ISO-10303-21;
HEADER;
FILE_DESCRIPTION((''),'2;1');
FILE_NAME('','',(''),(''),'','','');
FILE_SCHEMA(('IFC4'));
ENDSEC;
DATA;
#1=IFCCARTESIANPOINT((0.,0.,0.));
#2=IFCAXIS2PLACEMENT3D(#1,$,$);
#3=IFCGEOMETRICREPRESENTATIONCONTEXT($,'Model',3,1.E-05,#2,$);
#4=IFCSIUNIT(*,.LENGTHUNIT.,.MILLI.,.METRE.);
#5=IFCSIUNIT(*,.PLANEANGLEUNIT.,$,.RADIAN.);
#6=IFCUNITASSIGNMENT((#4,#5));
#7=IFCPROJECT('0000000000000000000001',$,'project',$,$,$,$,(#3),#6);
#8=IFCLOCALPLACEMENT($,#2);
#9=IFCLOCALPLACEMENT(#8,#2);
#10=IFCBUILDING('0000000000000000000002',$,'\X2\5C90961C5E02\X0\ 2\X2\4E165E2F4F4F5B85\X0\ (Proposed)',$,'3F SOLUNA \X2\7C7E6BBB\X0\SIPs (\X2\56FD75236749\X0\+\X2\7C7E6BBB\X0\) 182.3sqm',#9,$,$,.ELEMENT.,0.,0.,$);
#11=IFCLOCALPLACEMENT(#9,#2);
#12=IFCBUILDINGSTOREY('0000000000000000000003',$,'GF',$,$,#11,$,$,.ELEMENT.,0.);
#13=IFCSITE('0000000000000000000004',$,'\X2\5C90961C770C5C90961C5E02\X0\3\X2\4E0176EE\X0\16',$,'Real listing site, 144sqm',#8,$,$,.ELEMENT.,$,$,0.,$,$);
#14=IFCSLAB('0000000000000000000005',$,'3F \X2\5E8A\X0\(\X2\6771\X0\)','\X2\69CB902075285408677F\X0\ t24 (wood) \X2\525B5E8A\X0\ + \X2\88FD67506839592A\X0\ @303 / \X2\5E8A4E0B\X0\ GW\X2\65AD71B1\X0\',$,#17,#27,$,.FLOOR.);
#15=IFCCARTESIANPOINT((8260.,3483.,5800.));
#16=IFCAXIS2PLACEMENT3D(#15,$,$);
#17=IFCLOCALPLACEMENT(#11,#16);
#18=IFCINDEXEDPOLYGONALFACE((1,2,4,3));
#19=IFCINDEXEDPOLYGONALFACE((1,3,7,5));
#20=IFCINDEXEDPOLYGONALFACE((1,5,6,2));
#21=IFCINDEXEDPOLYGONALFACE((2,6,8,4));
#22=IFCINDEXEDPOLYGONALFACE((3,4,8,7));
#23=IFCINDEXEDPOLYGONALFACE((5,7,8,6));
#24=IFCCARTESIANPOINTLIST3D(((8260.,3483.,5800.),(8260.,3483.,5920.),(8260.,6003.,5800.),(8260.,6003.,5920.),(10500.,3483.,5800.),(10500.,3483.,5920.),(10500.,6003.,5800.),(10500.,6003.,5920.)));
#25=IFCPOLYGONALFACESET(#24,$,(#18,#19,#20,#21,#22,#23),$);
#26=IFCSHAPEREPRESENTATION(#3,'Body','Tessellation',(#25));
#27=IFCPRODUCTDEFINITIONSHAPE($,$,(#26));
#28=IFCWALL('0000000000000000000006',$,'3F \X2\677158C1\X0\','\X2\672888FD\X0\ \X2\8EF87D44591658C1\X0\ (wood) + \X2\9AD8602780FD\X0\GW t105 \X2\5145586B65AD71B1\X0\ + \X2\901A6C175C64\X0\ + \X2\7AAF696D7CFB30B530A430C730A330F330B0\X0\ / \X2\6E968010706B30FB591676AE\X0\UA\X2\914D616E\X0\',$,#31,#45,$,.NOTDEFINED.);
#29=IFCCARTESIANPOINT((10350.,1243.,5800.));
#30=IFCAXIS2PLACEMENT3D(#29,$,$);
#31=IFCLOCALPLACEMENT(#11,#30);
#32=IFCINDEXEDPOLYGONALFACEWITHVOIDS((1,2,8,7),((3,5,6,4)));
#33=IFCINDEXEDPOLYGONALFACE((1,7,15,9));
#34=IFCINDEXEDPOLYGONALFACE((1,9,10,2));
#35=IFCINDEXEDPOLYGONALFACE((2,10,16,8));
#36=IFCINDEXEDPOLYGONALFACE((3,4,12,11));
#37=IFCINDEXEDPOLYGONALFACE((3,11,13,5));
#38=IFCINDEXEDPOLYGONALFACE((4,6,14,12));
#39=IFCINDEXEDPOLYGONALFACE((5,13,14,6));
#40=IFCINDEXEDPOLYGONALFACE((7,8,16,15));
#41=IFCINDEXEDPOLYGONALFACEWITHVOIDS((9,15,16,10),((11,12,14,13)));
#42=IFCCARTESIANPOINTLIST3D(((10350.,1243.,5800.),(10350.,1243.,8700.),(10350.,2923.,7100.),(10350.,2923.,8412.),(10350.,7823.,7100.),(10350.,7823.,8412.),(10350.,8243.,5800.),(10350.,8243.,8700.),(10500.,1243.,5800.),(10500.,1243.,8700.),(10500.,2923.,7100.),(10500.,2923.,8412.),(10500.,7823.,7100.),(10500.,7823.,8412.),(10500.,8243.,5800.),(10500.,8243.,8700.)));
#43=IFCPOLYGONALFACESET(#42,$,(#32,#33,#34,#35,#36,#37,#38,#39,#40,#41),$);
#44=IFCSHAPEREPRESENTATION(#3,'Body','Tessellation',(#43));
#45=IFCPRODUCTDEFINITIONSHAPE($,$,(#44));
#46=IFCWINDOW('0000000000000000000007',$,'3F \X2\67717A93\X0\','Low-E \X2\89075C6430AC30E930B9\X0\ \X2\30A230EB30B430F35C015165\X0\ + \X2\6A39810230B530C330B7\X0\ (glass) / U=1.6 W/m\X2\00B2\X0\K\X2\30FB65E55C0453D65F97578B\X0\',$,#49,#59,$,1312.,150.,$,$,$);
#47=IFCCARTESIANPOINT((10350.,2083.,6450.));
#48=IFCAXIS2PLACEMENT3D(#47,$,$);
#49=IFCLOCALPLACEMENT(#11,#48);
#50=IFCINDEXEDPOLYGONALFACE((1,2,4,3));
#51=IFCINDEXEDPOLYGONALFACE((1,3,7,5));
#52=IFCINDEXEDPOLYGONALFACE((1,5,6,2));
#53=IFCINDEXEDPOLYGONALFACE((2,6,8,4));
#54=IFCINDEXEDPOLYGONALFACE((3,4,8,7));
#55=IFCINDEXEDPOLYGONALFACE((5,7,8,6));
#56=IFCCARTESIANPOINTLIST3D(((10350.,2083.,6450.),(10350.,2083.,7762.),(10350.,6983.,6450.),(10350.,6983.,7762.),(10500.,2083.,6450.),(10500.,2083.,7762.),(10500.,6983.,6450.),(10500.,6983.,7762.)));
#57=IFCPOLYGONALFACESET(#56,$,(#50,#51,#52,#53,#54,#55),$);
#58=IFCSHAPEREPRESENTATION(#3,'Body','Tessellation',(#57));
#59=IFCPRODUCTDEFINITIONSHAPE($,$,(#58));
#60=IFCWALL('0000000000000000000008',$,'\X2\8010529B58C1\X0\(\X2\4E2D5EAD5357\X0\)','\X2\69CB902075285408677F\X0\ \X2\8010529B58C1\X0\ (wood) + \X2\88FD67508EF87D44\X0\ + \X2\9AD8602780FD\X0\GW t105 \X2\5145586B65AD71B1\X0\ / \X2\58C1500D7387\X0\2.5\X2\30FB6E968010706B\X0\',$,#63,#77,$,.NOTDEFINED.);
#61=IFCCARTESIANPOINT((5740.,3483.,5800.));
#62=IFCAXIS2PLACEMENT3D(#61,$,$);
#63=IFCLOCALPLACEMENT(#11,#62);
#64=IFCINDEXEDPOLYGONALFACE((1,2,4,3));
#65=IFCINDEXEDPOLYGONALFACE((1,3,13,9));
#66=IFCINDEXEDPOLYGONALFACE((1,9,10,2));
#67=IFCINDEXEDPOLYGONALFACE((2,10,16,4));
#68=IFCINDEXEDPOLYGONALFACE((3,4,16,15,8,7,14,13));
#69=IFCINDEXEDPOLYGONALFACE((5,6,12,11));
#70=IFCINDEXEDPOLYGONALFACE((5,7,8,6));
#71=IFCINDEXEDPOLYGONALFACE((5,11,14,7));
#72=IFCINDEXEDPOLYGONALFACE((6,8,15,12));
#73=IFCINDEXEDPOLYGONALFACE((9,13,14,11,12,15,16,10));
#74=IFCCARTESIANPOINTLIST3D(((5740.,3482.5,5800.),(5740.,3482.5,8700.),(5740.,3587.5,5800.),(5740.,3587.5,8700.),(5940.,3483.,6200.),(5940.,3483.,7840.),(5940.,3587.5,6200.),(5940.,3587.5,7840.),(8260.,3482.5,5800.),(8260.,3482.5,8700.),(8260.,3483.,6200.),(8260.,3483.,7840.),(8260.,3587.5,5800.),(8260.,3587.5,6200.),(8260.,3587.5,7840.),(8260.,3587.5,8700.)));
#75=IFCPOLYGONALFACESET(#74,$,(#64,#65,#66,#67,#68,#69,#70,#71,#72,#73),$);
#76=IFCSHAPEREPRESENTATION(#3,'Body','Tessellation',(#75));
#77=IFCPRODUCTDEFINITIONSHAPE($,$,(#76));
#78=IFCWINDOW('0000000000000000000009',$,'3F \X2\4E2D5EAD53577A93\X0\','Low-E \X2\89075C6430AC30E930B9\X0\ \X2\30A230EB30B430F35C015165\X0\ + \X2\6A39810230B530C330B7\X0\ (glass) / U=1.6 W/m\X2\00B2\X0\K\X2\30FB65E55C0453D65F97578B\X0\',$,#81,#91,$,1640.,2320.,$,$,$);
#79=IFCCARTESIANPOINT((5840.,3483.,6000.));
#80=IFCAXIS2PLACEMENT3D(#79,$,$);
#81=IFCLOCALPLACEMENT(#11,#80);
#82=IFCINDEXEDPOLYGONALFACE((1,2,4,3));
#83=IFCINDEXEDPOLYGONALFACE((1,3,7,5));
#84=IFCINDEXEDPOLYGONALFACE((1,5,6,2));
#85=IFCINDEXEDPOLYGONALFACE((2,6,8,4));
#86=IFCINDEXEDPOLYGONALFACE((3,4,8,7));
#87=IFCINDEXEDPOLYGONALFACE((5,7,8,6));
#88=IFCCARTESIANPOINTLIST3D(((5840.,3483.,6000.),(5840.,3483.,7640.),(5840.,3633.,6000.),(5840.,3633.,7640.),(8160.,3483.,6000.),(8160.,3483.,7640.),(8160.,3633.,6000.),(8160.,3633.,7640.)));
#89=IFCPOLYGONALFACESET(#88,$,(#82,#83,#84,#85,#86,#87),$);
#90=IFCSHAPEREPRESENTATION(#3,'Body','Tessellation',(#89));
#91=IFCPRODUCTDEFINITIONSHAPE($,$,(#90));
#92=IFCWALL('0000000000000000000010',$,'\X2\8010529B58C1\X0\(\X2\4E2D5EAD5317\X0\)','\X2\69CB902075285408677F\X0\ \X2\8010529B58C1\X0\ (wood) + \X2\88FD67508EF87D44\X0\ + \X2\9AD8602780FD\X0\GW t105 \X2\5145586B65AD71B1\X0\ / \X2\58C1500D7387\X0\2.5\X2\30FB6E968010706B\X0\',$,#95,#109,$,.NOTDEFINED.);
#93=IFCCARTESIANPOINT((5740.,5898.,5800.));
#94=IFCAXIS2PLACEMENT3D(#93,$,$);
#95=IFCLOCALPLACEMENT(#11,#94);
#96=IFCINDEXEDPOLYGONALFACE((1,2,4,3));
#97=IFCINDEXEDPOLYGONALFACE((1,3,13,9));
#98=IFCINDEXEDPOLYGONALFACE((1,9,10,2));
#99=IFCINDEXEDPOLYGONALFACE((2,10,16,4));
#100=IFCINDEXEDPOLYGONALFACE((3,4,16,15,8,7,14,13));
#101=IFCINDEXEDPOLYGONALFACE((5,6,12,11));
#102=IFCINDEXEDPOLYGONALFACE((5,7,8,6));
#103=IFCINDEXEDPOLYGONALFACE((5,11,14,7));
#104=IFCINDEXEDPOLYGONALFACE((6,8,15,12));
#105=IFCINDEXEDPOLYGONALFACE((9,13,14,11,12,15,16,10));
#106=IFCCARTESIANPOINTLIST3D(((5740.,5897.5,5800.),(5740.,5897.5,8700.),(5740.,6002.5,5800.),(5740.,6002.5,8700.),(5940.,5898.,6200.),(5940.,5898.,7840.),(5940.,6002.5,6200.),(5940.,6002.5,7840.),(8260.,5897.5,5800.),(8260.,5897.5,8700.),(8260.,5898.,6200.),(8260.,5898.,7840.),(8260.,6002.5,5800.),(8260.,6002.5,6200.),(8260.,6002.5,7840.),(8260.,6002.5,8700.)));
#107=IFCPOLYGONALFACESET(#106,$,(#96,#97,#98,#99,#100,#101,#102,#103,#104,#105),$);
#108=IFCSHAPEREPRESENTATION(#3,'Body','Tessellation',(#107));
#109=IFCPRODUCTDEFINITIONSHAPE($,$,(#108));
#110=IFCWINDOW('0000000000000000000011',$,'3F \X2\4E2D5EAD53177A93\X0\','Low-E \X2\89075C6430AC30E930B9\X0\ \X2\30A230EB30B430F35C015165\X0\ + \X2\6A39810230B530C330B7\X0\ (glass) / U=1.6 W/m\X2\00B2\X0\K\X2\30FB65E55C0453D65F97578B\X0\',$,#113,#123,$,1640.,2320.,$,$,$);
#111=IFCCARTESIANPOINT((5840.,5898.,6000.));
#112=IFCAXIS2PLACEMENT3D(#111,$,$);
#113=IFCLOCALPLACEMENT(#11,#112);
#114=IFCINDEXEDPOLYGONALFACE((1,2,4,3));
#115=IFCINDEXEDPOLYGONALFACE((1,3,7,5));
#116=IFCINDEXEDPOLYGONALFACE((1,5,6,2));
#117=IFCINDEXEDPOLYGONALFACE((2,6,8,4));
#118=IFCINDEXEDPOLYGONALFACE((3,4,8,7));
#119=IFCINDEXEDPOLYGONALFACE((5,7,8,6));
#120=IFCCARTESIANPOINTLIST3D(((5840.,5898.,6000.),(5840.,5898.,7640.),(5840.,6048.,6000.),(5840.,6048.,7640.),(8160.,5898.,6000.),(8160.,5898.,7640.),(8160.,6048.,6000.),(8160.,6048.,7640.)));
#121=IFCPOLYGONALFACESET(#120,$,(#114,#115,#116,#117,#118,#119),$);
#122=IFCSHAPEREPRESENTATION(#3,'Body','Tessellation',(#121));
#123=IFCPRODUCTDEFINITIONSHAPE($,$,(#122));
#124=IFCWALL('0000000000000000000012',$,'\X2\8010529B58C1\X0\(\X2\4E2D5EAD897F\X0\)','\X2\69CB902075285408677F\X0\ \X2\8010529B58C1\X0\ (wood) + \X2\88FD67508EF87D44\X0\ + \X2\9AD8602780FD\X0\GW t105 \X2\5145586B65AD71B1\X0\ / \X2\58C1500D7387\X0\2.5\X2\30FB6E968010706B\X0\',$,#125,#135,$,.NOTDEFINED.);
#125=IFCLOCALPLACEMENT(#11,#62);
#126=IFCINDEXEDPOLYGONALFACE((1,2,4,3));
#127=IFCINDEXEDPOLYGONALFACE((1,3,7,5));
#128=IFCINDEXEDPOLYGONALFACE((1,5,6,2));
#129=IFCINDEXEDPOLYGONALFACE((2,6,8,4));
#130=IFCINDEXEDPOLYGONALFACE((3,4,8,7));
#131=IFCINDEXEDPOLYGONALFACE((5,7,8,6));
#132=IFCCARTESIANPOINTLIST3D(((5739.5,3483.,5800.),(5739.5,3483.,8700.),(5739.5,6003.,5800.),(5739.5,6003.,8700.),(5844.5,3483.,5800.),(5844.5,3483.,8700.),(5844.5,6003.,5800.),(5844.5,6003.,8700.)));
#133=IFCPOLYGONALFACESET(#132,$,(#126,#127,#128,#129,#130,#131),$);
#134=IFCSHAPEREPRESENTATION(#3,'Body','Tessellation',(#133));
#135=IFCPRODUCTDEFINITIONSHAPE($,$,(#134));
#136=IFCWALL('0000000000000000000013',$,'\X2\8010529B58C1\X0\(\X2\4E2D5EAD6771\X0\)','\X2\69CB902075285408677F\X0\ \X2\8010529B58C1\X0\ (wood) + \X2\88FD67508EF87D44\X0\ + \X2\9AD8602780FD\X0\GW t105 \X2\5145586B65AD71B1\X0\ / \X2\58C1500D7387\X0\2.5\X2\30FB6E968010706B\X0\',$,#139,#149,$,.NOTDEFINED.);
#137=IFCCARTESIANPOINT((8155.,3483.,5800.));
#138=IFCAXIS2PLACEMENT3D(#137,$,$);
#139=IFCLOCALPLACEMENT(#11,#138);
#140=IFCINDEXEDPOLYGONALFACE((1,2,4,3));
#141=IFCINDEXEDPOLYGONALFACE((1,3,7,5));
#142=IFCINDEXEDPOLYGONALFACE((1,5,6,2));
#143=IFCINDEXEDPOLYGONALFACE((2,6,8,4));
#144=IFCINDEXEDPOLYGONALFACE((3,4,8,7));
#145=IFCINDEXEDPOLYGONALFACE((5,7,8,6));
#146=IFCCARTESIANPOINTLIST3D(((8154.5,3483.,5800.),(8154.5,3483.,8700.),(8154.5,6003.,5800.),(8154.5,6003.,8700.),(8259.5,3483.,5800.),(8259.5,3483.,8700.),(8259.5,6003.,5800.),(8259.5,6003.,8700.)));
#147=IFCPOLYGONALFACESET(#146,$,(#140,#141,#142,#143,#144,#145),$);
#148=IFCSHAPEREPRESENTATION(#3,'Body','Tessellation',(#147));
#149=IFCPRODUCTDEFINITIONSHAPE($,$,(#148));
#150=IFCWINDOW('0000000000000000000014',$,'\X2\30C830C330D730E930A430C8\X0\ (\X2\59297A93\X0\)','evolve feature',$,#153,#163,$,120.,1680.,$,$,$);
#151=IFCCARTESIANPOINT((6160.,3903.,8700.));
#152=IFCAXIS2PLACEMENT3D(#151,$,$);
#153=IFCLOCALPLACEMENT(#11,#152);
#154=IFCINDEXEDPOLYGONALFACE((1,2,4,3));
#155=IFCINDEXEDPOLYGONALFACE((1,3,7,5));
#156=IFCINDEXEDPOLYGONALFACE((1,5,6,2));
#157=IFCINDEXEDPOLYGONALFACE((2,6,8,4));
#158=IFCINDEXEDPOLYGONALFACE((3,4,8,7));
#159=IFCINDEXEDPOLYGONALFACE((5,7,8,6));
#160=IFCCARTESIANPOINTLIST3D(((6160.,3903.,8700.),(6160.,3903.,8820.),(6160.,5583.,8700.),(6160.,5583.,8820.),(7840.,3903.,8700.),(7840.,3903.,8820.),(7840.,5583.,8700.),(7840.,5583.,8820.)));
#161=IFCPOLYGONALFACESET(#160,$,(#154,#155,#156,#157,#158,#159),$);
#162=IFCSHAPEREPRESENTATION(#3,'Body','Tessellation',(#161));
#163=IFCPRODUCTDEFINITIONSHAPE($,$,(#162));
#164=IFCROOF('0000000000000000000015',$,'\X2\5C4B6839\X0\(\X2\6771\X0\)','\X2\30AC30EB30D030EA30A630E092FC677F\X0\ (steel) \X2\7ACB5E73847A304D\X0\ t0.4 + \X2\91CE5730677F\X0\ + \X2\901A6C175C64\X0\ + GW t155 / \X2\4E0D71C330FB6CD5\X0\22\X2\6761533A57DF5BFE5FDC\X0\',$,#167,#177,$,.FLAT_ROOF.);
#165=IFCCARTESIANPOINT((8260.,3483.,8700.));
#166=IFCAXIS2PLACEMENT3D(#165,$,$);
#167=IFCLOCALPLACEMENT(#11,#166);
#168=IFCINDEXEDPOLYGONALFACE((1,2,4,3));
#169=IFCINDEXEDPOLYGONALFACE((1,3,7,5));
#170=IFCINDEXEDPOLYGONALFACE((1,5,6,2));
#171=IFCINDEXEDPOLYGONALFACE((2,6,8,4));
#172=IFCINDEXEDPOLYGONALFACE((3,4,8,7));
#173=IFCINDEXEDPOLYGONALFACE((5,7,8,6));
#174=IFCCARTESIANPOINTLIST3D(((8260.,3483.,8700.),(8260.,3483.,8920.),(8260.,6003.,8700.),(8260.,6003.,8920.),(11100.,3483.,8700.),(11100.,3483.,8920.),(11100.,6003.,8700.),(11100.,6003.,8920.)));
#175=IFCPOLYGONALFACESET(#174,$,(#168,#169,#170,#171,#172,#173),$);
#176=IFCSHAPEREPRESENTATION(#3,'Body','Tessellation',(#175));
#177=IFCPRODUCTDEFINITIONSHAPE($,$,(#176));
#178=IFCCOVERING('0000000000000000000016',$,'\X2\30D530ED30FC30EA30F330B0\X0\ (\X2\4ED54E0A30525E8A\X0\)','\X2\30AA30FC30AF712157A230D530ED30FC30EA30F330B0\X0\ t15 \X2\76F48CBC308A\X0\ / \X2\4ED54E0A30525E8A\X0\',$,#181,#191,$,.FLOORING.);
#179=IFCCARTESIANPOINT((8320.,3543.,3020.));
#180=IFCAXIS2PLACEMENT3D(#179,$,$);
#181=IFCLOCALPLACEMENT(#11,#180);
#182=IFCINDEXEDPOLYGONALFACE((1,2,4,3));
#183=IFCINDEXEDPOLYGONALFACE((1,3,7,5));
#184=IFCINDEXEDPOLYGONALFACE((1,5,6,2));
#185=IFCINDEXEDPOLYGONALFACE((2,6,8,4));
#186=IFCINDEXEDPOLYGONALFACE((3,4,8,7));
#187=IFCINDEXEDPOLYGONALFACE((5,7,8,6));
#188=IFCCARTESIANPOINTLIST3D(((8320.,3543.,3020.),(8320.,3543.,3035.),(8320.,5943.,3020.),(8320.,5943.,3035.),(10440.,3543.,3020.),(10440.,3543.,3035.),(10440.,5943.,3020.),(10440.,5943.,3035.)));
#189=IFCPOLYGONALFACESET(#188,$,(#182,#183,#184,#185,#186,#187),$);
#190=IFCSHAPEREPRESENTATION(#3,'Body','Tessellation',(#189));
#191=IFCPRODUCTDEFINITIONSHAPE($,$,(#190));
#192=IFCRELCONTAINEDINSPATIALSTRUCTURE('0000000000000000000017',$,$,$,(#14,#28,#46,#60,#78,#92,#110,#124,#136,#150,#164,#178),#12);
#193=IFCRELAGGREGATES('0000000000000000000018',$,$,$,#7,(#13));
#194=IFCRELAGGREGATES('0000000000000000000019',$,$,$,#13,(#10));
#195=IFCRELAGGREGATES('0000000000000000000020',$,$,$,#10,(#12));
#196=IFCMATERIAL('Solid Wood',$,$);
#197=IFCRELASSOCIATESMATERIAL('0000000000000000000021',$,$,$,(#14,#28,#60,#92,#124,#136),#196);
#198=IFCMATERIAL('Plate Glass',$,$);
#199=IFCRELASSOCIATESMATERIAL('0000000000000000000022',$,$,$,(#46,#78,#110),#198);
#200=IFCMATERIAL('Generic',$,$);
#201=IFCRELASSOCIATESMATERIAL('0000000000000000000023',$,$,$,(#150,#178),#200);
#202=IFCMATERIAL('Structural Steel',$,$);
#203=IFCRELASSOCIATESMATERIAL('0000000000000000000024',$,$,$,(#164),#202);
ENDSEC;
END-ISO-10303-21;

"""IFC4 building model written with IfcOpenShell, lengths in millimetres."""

from ifc_helpers import new_model, si_unit, frame, frame_2d, origin, place, context, project, spatial, rectangle, extrude, material, element, fill, save


model = new_model("IFC4")

# Units and contexts
model_context = context("Model", 3, precision=1e-05, world=origin())
ifc_project = project(units=[si_unit("LENGTHUNIT", "METRE", prefix="MILLI"), si_unit("PLANEANGLEUNIT", "RADIAN")], contexts=[model_context])

# Site, building, storey
site_placement = place(None, origin())
site = spatial("IfcSite", under=ifc_project, at=site_placement, Name="岐阜県岐阜市3丁目16", ObjectType="Real listing site, 144sqm", CompositionType="ELEMENT", RefElevation=0.0)
building_placement = place(site_placement, origin())
building = spatial("IfcBuilding", under=site, at=building_placement, Name="岐阜市 2世帯住宅 (Proposed)", ObjectType="3F SOLUNA 籾殻SIPs (国産杉+籾殻) 182.3sqm", CompositionType="ELEMENT", ElevationOfRefHeight=0.0, ElevationOfTerrain=0.0)
storey_placement = place(building_placement, origin())
storey = spatial("IfcBuildingStorey", under=building, at=storey_placement, Name="GF", CompositionType="ELEMENT", Elevation=0.0)

# Slab
ifc_material_1 = material(Name="Solid Wood")
slab_placement = place(storey_placement, frame((8260.0, 3483.0, 5800.0)))
element("IfcSlab", 1, at=slab_placement, inside=storey, material=ifc_material_1, Name="3F 床(東)", Description="構造用合板 t24 (wood) 剛床 + 製材根太 @303 / 床下 GW断熱", PredefinedType="FLOOR", context=model_context, shape_type="SweptSolid", body=[
    extrude(rectangle(XDim=2240.0, YDim=2520.0, at=frame_2d((1120.0, 1260.0))), frame((8260.0, 3483.0, 5800.0)), (0.0, 0.0, 1.0), 120.0),
])

# Walls, openings, windows
wall_1_placement = place(storey_placement, frame((10350.0, 1243.0, 5800.0)))
wall_1 = element("IfcWall", 2, at=wall_1_placement, inside=storey, material=ifc_material_1, Name="3F 東壁", Description="木製 軸組外壁 (wood) + 高性能GW t105 充填断熱 + 通気層 + 窯業系サイディング / 準耐火・外皮UA配慮", PredefinedType="NOTDEFINED", context=model_context, shape_type="SweptSolid", body=[
    extrude(rectangle(XDim=150.0, YDim=7000.0, at=frame_2d((75.0, 3500.0))), frame((10350.0, 1243.0, 5800.0)), (0.0, 0.0, 1.0), 2900.0),
])
opening_1_placement = place(storey_placement, frame((10350.0, 2083.0, 6450.0)))
opening_1 = element("IfcOpeningElement", 3, at=opening_1_placement, cuts=wall_1, PredefinedType="NOTDEFINED", context=model_context, shape_type="SweptSolid", body=[
    extrude(rectangle(XDim=150.0, YDim=4900.0, at=frame_2d((75.0, 2450.0))), frame((10350.0, 2083.0, 6450.0)), (0.0, 0.0, 1.0), 1312.0),
])
ifc_material_2 = material(Name="Plate Glass")
window_1_placement = place(storey_placement, frame((10350.0, 2083.0, 6450.0)))
window_1 = element("IfcWindow", 4, at=window_1_placement, inside=storey, material=ifc_material_2, Name="3F 東窓", Description="Low-E 複層ガラス アルゴン封入 + 樹脂サッシ (glass) / U=1.6 W/m²K・日射取得型", OverallHeight=1312.0, OverallWidth=150.0, context=model_context, shape_type="SweptSolid", body=[
    extrude(rectangle(XDim=150.0, YDim=4900.0, at=frame_2d((75.0, 2450.0))), frame((10350.0, 2083.0, 6450.0)), (0.0, 0.0, 1.0), 1312.0),
])
fill(opening_1, window_1)
wall_2_placement = place(storey_placement, frame((5740.0, 3483.0, 5800.0)))
wall_2 = element("IfcWall", 5, at=wall_2_placement, inside=storey, material=ifc_material_1, Name="耐力壁(中庭南)", Description="構造用合板 耐力壁 (wood) + 製材軸組 + 高性能GW t105 充填断熱 / 壁倍率2.5・準耐火", PredefinedType="NOTDEFINED", context=model_context, shape_type="SweptSolid", body=[
    extrude(rectangle(XDim=2520.0, YDim=105.0, at=frame_2d((1260.0, 52.0))), frame((5740.0, 3483.0, 5800.0)), (0.0, 0.0, 1.0), 2900.0),
])
opening_2_placement = place(storey_placement, frame((5840.0, 3483.0, 6000.0)))
opening_2 = element("IfcOpeningElement", 6, at=opening_2_placement, cuts=wall_2, PredefinedType="NOTDEFINED", context=model_context, shape_type="SweptSolid", body=[
    extrude(rectangle(XDim=2320.0, YDim=150.0, at=frame_2d((1160.0, 75.0))), frame((5840.0, 3483.0, 6000.0)), (0.0, 0.0, 1.0), 1640.0),
])
window_2_placement = place(storey_placement, frame((5840.0, 3483.0, 6000.0)))
window_2 = element("IfcWindow", 7, at=window_2_placement, inside=storey, material=ifc_material_2, Name="3F 中庭南窓", Description="Low-E 複層ガラス アルゴン封入 + 樹脂サッシ (glass) / U=1.6 W/m²K・日射取得型", OverallHeight=1640.0, OverallWidth=2320.0, context=model_context, shape_type="SweptSolid", body=[
    extrude(rectangle(XDim=2320.0, YDim=150.0, at=frame_2d((1160.0, 75.0))), frame((5840.0, 3483.0, 6000.0)), (0.0, 0.0, 1.0), 1640.0),
])
fill(opening_2, window_2)
wall_3_placement = place(storey_placement, frame((5740.0, 5898.0, 5800.0)))
wall_3 = element("IfcWall", 8, at=wall_3_placement, inside=storey, material=ifc_material_1, Name="耐力壁(中庭北)", Description="構造用合板 耐力壁 (wood) + 製材軸組 + 高性能GW t105 充填断熱 / 壁倍率2.5・準耐火", PredefinedType="NOTDEFINED", context=model_context, shape_type="SweptSolid", body=[
    extrude(rectangle(XDim=2520.0, YDim=105.0, at=frame_2d((1260.0, 52.0))), frame((5740.0, 5898.0, 5800.0)), (0.0, 0.0, 1.0), 2900.0),
])
opening_3_placement = place(storey_placement, frame((5840.0, 5898.0, 6000.0)))
opening_3 = element("IfcOpeningElement", 9, at=opening_3_placement, cuts=wall_3, PredefinedType="NOTDEFINED", context=model_context, shape_type="SweptSolid", body=[
    extrude(rectangle(XDim=2320.0, YDim=150.0, at=frame_2d((1160.0, 75.0))), frame((5840.0, 5898.0, 6000.0)), (0.0, 0.0, 1.0), 1640.0),
])
window_3_placement = place(storey_placement, frame((5840.0, 5898.0, 6000.0)))
window_3 = element("IfcWindow", 10, at=window_3_placement, inside=storey, material=ifc_material_2, Name="3F 中庭北窓", Description="Low-E 複層ガラス アルゴン封入 + 樹脂サッシ (glass) / U=1.6 W/m²K・日射取得型", OverallHeight=1640.0, OverallWidth=2320.0, context=model_context, shape_type="SweptSolid", body=[
    extrude(rectangle(XDim=2320.0, YDim=150.0, at=frame_2d((1160.0, 75.0))), frame((5840.0, 5898.0, 6000.0)), (0.0, 0.0, 1.0), 1640.0),
])
fill(opening_3, window_3)

# Walls
wall_4_placement = place(storey_placement, frame((5740.0, 3483.0, 5800.0)))
element("IfcWall", 11, at=wall_4_placement, inside=storey, material=ifc_material_1, Name="耐力壁(中庭西)", Description="構造用合板 耐力壁 (wood) + 製材軸組 + 高性能GW t105 充填断熱 / 壁倍率2.5・準耐火", PredefinedType="NOTDEFINED", context=model_context, shape_type="SweptSolid", body=[
    extrude(rectangle(XDim=105.0, YDim=2520.0, at=frame_2d((52.0, 1260.0))), frame((5740.0, 3483.0, 5800.0)), (0.0, 0.0, 1.0), 2900.0),
])
wall_5_placement = place(storey_placement, frame((8155.0, 3483.0, 5800.0)))
element("IfcWall", 12, at=wall_5_placement, inside=storey, material=ifc_material_1, Name="耐力壁(中庭東)", Description="構造用合板 耐力壁 (wood) + 製材軸組 + 高性能GW t105 充填断熱 / 壁倍率2.5・準耐火", PredefinedType="NOTDEFINED", context=model_context, shape_type="SweptSolid", body=[
    extrude(rectangle(XDim=105.0, YDim=2520.0, at=frame_2d((52.0, 1260.0))), frame((8155.0, 3483.0, 5800.0)), (0.0, 0.0, 1.0), 2900.0),
])

# Window
ifc_material_3 = material(Name="Generic")
window_4_placement = place(storey_placement, frame((6160.0, 3903.0, 8700.0)))
element("IfcWindow", 13, at=window_4_placement, inside=storey, material=ifc_material_3, Name="トップライト (天窓)", Description="evolve feature", OverallHeight=120.0, OverallWidth=1680.0, context=model_context, shape_type="SweptSolid", body=[
    extrude(rectangle(XDim=1680.0, YDim=1680.0, at=frame_2d((840.0, 840.0))), frame((6160.0, 3903.0, 8700.0)), (0.0, 0.0, 1.0), 120.0),
])

# Roof
ifc_material_4 = material(Name="Structural Steel")
for number, where, name in (
    (14, (8260.0, 3483.0, 8700.0), "屋根(東)"),
):
    element("IfcRoof", number, at=place(storey_placement, frame(where)), inside=storey, material=ifc_material_4, Name=name, Description="ガルバリウム鋼板 (steel) 立平葺き t0.4 + 野地板 + 通気層 + GW t155 / 不燃・法22条区域対応", PredefinedType="FLAT_ROOF", context=model_context, shape_type="SweptSolid", body=[
        extrude(rectangle(XDim=2840.0, YDim=2520.0, at=frame_2d((1420.0, 1260.0))), frame((8260.0, 3483.0, 8700.0)), (0.0, 0.0, 1.0), 220.0),
    ])

# Covering
covering_1_placement = place(storey_placement, frame((8320.0, 3543.0, 3020.0)))
element("IfcCovering", 15, at=covering_1_placement, inside=storey, material=ifc_material_3, Name="フローリング (仕上げ床)", Description="オーク無垢フローリング t15 直貼り / 仕上げ床", PredefinedType="FLOORING", context=model_context, shape_type="SweptSolid", body=[
    extrude(rectangle(XDim=2120.0, YDim=2400.0, at=frame_2d((1060.0, 1200.0))), frame((8320.0, 3543.0, 3020.0)), (0.0, 0.0, 1.0), 15.0),
])

save(model, "model.ifc")
